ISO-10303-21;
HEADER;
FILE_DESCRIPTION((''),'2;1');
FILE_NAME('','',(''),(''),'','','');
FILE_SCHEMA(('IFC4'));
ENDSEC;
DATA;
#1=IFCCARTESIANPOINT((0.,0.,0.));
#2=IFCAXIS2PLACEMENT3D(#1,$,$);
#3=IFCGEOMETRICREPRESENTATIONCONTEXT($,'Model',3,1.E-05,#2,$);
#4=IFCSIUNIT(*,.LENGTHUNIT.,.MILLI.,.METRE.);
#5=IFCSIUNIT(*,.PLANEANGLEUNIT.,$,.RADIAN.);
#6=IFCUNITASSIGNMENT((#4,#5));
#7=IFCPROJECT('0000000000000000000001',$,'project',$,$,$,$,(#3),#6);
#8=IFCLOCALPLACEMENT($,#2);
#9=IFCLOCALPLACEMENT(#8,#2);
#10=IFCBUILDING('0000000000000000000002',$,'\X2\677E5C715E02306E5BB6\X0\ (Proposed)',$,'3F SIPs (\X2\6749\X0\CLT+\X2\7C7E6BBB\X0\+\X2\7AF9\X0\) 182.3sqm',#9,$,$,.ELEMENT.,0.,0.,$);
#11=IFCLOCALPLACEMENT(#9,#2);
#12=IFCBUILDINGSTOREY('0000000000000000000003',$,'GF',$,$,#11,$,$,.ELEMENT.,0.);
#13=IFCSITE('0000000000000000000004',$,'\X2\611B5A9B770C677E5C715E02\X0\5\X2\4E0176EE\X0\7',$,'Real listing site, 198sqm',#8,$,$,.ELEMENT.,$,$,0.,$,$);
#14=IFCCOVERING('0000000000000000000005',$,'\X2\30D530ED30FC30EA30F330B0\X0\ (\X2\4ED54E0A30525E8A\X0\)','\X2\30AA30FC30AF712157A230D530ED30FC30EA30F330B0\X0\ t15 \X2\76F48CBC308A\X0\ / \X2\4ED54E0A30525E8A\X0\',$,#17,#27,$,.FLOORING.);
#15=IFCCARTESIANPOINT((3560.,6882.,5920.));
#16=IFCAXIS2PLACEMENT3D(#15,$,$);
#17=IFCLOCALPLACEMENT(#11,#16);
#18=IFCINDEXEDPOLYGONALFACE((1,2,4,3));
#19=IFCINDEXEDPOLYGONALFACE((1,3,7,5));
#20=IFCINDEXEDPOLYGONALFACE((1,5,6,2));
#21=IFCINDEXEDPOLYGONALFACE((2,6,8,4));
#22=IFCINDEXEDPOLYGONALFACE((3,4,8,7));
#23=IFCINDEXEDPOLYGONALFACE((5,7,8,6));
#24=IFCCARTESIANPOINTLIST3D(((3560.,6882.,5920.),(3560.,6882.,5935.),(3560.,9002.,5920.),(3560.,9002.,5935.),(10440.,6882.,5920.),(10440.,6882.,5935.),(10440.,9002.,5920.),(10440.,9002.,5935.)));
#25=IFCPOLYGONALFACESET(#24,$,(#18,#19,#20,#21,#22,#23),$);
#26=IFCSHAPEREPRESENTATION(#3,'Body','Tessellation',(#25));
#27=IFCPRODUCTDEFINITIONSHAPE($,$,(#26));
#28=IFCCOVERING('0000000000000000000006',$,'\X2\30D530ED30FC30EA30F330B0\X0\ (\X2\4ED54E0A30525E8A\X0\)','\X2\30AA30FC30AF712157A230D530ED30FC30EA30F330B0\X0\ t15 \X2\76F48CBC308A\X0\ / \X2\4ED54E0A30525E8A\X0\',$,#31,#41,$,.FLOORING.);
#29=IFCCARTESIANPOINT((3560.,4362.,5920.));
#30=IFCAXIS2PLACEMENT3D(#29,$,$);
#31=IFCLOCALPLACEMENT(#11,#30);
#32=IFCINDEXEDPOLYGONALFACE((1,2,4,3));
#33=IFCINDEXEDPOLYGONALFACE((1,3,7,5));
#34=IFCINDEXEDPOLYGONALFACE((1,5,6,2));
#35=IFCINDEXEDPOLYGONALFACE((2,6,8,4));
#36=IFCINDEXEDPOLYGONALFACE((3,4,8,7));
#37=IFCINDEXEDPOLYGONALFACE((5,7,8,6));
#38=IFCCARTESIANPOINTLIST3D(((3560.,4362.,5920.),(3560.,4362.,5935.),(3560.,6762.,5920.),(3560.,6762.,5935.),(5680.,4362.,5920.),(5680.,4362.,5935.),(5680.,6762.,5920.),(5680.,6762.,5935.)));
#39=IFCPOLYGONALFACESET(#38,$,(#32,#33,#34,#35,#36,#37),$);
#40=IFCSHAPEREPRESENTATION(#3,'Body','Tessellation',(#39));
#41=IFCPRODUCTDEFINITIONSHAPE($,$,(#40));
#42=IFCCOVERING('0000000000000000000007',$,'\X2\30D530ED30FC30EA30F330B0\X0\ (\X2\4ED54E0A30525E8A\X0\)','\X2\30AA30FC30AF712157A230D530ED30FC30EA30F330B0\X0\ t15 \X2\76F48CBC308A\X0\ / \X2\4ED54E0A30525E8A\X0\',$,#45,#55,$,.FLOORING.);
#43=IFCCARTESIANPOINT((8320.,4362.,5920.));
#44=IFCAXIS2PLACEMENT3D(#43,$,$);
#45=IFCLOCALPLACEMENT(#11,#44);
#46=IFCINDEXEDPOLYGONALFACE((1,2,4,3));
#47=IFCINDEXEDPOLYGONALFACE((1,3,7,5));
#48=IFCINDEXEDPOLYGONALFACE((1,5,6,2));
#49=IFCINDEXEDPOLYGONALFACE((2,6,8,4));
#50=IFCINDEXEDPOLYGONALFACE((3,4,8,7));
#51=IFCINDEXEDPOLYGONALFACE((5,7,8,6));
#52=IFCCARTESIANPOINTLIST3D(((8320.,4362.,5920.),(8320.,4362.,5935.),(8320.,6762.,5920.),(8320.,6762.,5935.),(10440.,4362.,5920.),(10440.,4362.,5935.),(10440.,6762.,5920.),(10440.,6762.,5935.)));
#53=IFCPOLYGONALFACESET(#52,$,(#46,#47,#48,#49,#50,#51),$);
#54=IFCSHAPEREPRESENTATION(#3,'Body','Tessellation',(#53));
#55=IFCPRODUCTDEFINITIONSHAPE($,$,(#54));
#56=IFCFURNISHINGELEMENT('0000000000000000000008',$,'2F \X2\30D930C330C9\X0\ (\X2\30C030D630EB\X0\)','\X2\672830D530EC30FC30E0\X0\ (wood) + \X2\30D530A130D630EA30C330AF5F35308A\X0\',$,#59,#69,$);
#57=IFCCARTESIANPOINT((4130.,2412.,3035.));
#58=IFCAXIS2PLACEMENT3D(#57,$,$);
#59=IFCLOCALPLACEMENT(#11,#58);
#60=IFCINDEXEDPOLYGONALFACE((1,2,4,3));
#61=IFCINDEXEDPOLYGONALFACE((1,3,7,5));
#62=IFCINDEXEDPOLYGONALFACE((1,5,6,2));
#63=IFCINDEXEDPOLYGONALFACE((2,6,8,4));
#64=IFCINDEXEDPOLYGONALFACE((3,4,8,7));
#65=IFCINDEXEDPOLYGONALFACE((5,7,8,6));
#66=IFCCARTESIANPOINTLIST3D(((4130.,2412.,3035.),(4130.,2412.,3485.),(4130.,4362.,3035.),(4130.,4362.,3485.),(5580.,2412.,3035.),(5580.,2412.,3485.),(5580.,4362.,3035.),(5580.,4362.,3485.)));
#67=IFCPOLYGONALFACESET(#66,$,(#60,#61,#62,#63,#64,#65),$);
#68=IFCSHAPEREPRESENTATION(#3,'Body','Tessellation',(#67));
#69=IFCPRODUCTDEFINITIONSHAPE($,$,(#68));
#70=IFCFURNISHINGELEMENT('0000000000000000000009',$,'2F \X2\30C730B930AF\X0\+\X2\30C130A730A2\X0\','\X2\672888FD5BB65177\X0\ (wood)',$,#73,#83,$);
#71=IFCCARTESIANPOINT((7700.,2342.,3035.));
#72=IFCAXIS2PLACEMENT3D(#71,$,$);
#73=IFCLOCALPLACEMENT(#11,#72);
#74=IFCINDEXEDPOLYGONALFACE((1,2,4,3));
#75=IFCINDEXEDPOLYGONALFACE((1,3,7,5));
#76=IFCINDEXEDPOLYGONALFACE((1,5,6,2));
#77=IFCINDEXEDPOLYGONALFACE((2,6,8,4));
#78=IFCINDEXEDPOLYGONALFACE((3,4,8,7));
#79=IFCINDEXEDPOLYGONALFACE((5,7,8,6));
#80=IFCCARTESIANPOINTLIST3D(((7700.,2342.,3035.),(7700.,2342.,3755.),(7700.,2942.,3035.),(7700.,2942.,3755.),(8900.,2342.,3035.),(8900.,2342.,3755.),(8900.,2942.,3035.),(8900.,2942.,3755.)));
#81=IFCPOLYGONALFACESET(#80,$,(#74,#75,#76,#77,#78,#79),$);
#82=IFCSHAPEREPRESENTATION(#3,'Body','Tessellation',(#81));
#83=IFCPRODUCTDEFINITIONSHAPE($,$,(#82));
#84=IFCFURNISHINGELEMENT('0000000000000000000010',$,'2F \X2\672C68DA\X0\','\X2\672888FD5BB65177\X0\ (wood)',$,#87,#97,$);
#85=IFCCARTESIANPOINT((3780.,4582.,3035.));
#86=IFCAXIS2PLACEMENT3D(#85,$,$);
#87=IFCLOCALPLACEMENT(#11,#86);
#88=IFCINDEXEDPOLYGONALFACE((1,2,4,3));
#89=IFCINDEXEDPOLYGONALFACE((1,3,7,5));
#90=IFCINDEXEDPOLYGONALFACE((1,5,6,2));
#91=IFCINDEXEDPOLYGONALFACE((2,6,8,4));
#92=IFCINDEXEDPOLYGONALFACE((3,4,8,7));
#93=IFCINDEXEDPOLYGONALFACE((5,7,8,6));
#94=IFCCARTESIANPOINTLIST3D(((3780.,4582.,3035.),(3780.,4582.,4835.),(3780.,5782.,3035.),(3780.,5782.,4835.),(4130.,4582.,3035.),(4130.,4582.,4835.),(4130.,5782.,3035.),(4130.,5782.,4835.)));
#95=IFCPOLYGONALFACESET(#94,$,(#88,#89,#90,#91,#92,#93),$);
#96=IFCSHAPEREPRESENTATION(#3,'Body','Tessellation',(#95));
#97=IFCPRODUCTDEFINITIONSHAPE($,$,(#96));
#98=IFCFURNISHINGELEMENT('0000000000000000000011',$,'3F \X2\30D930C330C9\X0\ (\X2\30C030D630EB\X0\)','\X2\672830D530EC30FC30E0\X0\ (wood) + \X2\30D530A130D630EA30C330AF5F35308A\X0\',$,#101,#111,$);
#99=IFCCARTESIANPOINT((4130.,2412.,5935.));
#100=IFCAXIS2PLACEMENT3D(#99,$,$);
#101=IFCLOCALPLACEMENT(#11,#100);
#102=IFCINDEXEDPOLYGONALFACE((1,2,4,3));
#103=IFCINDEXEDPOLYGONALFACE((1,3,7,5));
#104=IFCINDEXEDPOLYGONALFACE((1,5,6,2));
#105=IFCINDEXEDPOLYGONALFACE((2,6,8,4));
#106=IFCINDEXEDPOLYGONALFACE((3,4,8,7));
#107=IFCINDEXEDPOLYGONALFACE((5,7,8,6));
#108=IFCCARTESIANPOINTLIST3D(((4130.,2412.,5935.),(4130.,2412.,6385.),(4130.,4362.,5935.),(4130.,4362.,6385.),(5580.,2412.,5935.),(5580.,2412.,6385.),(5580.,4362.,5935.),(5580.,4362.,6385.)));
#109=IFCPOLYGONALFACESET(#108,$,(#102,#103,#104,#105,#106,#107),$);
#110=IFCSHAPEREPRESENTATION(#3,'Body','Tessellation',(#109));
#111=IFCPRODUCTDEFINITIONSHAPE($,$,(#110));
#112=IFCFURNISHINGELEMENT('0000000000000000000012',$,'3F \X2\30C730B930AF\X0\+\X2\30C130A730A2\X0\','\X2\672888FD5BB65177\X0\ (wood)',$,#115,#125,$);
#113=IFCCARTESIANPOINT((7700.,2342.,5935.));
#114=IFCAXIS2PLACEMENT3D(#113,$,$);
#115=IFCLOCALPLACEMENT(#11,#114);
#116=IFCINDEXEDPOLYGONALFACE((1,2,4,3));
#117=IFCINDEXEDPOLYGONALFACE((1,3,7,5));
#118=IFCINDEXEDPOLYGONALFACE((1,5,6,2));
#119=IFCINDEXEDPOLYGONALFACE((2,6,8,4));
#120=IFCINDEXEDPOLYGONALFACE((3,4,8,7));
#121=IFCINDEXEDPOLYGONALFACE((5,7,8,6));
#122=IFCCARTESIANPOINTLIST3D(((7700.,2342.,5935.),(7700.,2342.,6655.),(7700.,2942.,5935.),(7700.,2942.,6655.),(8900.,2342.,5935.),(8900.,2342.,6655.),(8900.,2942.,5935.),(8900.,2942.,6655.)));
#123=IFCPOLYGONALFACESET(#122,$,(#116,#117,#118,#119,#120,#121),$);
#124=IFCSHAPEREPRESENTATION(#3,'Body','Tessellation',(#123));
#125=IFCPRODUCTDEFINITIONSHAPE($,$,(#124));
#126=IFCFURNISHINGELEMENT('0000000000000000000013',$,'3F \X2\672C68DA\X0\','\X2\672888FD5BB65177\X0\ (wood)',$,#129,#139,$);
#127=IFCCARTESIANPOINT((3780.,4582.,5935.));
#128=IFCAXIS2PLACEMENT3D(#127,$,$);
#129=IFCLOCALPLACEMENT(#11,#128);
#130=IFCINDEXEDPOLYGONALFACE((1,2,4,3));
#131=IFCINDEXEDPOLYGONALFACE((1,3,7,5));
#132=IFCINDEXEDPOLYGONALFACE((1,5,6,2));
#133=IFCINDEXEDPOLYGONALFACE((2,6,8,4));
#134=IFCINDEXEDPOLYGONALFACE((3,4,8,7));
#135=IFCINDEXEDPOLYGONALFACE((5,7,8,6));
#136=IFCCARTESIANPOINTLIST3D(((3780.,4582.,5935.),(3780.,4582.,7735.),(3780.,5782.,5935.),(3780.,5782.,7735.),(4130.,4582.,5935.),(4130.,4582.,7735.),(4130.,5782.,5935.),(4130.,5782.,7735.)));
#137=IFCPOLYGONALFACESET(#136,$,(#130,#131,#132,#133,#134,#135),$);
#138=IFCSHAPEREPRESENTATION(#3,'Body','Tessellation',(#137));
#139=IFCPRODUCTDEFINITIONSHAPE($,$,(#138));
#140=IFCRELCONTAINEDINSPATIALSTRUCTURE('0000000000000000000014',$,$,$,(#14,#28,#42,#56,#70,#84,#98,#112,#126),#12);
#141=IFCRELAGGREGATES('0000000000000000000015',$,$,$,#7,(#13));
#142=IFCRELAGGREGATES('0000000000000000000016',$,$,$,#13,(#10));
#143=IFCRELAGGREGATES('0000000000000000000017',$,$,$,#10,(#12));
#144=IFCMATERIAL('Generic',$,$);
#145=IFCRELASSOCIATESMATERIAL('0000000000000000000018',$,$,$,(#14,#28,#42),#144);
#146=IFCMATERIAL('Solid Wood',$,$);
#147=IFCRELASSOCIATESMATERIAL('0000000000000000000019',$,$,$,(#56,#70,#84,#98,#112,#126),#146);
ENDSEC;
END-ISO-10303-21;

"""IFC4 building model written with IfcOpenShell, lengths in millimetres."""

from ifc_helpers import new_model, si_unit, frame, frame_2d, origin, place, context, project, spatial, rectangle, extrude, material, element, save


model = new_model("IFC4")

# Units and contexts
model_context = context("Model", 3, precision=1e-05, world=origin())
ifc_project = project(units=[si_unit("LENGTHUNIT", "METRE", prefix="MILLI"), si_unit("PLANEANGLEUNIT", "RADIAN")], contexts=[model_context])

# Site, building, storey
site_placement = place(None, origin())
site = spatial("IfcSite", under=ifc_project, at=site_placement, Name="愛媛県松山市5丁目7", ObjectType="Real listing site, 198sqm", CompositionType="ELEMENT", RefElevation=0.0)
building_placement = place(site_placement, origin())
building = spatial("IfcBuilding", under=site, at=building_placement, Name="松山市の家 (Proposed)", ObjectType="3F SIPs (杉CLT+籾殻+竹) 182.3sqm", CompositionType="ELEMENT", ElevationOfRefHeight=0.0, ElevationOfTerrain=0.0)
storey_placement = place(building_placement, origin())
storey = spatial("IfcBuildingStorey", under=building, at=storey_placement, Name="GF", CompositionType="ELEMENT", Elevation=0.0)

# Shared definitions
ifc_material_1 = material(Name="Solid Wood")

# Shared definitions
ifc_material_2 = material(Name="Generic")

# Coverings
covering_1_placement = place(storey_placement, frame((3560.0, 6882.0, 5920.0)))
element("IfcCovering", 1, at=covering_1_placement, inside=storey, material=ifc_material_2, Name="フローリング (仕上げ床)", Description="オーク無垢フローリング t15 直貼り / 仕上げ床", PredefinedType="FLOORING", context=model_context, shape_type="SweptSolid", body=[
    extrude(rectangle(XDim=6880.0, YDim=2120.0, at=frame_2d((3440.0, 1060.0))), frame((3560.0, 6882.0, 5920.0)), (0.0, 0.0, 1.0), 15.0),
])
covering_2_placement = place(storey_placement, frame((3560.0, 4362.0, 5920.0)))
element("IfcCovering", 2, at=covering_2_placement, inside=storey, material=ifc_material_2, Name="フローリング (仕上げ床)", Description="オーク無垢フローリング t15 直貼り / 仕上げ床", PredefinedType="FLOORING", context=model_context, shape_type="SweptSolid", body=[
    extrude(rectangle(XDim=2120.0, YDim=2400.0, at=frame_2d((1060.0, 1200.0))), frame((3560.0, 4362.0, 5920.0)), (0.0, 0.0, 1.0), 15.0),
])
covering_3_placement = place(storey_placement, frame((8320.0, 4362.0, 5920.0)))
element("IfcCovering", 3, at=covering_3_placement, inside=storey, material=ifc_material_2, Name="フローリング (仕上げ床)", Description="オーク無垢フローリング t15 直貼り / 仕上げ床", PredefinedType="FLOORING", context=model_context, shape_type="SweptSolid", body=[
    extrude(rectangle(XDim=2120.0, YDim=2400.0, at=frame_2d((1060.0, 1200.0))), frame((8320.0, 4362.0, 5920.0)), (0.0, 0.0, 1.0), 15.0),
])

# Furnishing elements
furnishing_1_placement = place(storey_placement, frame((4130.0, 2412.0, 3035.0)))
element("IfcFurnishingElement", 4, at=furnishing_1_placement, inside=storey, material=ifc_material_1, Name="2F ベッド (ダブル)", Description="木フレーム (wood) + ファブリック張り", context=model_context, shape_type="SweptSolid", body=[
    extrude(rectangle(XDim=1450.0, YDim=1950.0, at=frame_2d((725.0, 975.0))), frame((4130.0, 2412.0, 3035.0)), (0.0, 0.0, 1.0), 450.0),
])
furnishing_2_placement = place(storey_placement, frame((7700.0, 2342.0, 3035.0)))
element("IfcFurnishingElement", 5, at=furnishing_2_placement, inside=storey, material=ifc_material_1, Name="2F デスク+チェア", Description="木製家具 (wood)", context=model_context, shape_type="SweptSolid", body=[
    extrude(rectangle(XDim=1200.0, YDim=600.0, at=frame_2d((600.0, 300.0))), frame((7700.0, 2342.0, 3035.0)), (0.0, 0.0, 1.0), 720.0),
])
furnishing_3_placement = place(storey_placement, frame((3780.0, 4582.0, 3035.0)))
element("IfcFurnishingElement", 6, at=furnishing_3_placement, inside=storey, material=ifc_material_1, Name="2F 本棚", Description="木製家具 (wood)", context=model_context, shape_type="SweptSolid", body=[
    extrude(rectangle(XDim=350.0, YDim=1200.0, at=frame_2d((175.0, 600.0))), frame((3780.0, 4582.0, 3035.0)), (0.0, 0.0, 1.0), 1800.0),
])
furnishing_4_placement = place(storey_placement, frame((4130.0, 2412.0, 5935.0)))
element("IfcFurnishingElement", 7, at=furnishing_4_placement, inside=storey, material=ifc_material_1, Name="3F ベッド (ダブル)", Description="木フレーム (wood) + ファブリック張り", context=model_context, shape_type="SweptSolid", body=[
    extrude(rectangle(XDim=1450.0, YDim=1950.0, at=frame_2d((725.0, 975.0))), frame((4130.0, 2412.0, 5935.0)), (0.0, 0.0, 1.0), 450.0),
])
furnishing_5_placement = place(storey_placement, frame((7700.0, 2342.0, 5935.0)))
element("IfcFurnishingElement", 8, at=furnishing_5_placement, inside=storey, material=ifc_material_1, Name="3F デスク+チェア", Description="木製家具 (wood)", context=model_context, shape_type="SweptSolid", body=[
    extrude(rectangle(XDim=1200.0, YDim=600.0, at=frame_2d((600.0, 300.0))), frame((7700.0, 2342.0, 5935.0)), (0.0, 0.0, 1.0), 720.0),
])
furnishing_6_placement = place(storey_placement, frame((3780.0, 4582.0, 5935.0)))
element("IfcFurnishingElement", 9, at=furnishing_6_placement, inside=storey, material=ifc_material_1, Name="3F 本棚", Description="木製家具 (wood)", context=model_context, shape_type="SweptSolid", body=[
    extrude(rectangle(XDim=350.0, YDim=1200.0, at=frame_2d((175.0, 600.0))), frame((3780.0, 4582.0, 5935.0)), (0.0, 0.0, 1.0), 1800.0),
])

save(model, "model.ifc")
